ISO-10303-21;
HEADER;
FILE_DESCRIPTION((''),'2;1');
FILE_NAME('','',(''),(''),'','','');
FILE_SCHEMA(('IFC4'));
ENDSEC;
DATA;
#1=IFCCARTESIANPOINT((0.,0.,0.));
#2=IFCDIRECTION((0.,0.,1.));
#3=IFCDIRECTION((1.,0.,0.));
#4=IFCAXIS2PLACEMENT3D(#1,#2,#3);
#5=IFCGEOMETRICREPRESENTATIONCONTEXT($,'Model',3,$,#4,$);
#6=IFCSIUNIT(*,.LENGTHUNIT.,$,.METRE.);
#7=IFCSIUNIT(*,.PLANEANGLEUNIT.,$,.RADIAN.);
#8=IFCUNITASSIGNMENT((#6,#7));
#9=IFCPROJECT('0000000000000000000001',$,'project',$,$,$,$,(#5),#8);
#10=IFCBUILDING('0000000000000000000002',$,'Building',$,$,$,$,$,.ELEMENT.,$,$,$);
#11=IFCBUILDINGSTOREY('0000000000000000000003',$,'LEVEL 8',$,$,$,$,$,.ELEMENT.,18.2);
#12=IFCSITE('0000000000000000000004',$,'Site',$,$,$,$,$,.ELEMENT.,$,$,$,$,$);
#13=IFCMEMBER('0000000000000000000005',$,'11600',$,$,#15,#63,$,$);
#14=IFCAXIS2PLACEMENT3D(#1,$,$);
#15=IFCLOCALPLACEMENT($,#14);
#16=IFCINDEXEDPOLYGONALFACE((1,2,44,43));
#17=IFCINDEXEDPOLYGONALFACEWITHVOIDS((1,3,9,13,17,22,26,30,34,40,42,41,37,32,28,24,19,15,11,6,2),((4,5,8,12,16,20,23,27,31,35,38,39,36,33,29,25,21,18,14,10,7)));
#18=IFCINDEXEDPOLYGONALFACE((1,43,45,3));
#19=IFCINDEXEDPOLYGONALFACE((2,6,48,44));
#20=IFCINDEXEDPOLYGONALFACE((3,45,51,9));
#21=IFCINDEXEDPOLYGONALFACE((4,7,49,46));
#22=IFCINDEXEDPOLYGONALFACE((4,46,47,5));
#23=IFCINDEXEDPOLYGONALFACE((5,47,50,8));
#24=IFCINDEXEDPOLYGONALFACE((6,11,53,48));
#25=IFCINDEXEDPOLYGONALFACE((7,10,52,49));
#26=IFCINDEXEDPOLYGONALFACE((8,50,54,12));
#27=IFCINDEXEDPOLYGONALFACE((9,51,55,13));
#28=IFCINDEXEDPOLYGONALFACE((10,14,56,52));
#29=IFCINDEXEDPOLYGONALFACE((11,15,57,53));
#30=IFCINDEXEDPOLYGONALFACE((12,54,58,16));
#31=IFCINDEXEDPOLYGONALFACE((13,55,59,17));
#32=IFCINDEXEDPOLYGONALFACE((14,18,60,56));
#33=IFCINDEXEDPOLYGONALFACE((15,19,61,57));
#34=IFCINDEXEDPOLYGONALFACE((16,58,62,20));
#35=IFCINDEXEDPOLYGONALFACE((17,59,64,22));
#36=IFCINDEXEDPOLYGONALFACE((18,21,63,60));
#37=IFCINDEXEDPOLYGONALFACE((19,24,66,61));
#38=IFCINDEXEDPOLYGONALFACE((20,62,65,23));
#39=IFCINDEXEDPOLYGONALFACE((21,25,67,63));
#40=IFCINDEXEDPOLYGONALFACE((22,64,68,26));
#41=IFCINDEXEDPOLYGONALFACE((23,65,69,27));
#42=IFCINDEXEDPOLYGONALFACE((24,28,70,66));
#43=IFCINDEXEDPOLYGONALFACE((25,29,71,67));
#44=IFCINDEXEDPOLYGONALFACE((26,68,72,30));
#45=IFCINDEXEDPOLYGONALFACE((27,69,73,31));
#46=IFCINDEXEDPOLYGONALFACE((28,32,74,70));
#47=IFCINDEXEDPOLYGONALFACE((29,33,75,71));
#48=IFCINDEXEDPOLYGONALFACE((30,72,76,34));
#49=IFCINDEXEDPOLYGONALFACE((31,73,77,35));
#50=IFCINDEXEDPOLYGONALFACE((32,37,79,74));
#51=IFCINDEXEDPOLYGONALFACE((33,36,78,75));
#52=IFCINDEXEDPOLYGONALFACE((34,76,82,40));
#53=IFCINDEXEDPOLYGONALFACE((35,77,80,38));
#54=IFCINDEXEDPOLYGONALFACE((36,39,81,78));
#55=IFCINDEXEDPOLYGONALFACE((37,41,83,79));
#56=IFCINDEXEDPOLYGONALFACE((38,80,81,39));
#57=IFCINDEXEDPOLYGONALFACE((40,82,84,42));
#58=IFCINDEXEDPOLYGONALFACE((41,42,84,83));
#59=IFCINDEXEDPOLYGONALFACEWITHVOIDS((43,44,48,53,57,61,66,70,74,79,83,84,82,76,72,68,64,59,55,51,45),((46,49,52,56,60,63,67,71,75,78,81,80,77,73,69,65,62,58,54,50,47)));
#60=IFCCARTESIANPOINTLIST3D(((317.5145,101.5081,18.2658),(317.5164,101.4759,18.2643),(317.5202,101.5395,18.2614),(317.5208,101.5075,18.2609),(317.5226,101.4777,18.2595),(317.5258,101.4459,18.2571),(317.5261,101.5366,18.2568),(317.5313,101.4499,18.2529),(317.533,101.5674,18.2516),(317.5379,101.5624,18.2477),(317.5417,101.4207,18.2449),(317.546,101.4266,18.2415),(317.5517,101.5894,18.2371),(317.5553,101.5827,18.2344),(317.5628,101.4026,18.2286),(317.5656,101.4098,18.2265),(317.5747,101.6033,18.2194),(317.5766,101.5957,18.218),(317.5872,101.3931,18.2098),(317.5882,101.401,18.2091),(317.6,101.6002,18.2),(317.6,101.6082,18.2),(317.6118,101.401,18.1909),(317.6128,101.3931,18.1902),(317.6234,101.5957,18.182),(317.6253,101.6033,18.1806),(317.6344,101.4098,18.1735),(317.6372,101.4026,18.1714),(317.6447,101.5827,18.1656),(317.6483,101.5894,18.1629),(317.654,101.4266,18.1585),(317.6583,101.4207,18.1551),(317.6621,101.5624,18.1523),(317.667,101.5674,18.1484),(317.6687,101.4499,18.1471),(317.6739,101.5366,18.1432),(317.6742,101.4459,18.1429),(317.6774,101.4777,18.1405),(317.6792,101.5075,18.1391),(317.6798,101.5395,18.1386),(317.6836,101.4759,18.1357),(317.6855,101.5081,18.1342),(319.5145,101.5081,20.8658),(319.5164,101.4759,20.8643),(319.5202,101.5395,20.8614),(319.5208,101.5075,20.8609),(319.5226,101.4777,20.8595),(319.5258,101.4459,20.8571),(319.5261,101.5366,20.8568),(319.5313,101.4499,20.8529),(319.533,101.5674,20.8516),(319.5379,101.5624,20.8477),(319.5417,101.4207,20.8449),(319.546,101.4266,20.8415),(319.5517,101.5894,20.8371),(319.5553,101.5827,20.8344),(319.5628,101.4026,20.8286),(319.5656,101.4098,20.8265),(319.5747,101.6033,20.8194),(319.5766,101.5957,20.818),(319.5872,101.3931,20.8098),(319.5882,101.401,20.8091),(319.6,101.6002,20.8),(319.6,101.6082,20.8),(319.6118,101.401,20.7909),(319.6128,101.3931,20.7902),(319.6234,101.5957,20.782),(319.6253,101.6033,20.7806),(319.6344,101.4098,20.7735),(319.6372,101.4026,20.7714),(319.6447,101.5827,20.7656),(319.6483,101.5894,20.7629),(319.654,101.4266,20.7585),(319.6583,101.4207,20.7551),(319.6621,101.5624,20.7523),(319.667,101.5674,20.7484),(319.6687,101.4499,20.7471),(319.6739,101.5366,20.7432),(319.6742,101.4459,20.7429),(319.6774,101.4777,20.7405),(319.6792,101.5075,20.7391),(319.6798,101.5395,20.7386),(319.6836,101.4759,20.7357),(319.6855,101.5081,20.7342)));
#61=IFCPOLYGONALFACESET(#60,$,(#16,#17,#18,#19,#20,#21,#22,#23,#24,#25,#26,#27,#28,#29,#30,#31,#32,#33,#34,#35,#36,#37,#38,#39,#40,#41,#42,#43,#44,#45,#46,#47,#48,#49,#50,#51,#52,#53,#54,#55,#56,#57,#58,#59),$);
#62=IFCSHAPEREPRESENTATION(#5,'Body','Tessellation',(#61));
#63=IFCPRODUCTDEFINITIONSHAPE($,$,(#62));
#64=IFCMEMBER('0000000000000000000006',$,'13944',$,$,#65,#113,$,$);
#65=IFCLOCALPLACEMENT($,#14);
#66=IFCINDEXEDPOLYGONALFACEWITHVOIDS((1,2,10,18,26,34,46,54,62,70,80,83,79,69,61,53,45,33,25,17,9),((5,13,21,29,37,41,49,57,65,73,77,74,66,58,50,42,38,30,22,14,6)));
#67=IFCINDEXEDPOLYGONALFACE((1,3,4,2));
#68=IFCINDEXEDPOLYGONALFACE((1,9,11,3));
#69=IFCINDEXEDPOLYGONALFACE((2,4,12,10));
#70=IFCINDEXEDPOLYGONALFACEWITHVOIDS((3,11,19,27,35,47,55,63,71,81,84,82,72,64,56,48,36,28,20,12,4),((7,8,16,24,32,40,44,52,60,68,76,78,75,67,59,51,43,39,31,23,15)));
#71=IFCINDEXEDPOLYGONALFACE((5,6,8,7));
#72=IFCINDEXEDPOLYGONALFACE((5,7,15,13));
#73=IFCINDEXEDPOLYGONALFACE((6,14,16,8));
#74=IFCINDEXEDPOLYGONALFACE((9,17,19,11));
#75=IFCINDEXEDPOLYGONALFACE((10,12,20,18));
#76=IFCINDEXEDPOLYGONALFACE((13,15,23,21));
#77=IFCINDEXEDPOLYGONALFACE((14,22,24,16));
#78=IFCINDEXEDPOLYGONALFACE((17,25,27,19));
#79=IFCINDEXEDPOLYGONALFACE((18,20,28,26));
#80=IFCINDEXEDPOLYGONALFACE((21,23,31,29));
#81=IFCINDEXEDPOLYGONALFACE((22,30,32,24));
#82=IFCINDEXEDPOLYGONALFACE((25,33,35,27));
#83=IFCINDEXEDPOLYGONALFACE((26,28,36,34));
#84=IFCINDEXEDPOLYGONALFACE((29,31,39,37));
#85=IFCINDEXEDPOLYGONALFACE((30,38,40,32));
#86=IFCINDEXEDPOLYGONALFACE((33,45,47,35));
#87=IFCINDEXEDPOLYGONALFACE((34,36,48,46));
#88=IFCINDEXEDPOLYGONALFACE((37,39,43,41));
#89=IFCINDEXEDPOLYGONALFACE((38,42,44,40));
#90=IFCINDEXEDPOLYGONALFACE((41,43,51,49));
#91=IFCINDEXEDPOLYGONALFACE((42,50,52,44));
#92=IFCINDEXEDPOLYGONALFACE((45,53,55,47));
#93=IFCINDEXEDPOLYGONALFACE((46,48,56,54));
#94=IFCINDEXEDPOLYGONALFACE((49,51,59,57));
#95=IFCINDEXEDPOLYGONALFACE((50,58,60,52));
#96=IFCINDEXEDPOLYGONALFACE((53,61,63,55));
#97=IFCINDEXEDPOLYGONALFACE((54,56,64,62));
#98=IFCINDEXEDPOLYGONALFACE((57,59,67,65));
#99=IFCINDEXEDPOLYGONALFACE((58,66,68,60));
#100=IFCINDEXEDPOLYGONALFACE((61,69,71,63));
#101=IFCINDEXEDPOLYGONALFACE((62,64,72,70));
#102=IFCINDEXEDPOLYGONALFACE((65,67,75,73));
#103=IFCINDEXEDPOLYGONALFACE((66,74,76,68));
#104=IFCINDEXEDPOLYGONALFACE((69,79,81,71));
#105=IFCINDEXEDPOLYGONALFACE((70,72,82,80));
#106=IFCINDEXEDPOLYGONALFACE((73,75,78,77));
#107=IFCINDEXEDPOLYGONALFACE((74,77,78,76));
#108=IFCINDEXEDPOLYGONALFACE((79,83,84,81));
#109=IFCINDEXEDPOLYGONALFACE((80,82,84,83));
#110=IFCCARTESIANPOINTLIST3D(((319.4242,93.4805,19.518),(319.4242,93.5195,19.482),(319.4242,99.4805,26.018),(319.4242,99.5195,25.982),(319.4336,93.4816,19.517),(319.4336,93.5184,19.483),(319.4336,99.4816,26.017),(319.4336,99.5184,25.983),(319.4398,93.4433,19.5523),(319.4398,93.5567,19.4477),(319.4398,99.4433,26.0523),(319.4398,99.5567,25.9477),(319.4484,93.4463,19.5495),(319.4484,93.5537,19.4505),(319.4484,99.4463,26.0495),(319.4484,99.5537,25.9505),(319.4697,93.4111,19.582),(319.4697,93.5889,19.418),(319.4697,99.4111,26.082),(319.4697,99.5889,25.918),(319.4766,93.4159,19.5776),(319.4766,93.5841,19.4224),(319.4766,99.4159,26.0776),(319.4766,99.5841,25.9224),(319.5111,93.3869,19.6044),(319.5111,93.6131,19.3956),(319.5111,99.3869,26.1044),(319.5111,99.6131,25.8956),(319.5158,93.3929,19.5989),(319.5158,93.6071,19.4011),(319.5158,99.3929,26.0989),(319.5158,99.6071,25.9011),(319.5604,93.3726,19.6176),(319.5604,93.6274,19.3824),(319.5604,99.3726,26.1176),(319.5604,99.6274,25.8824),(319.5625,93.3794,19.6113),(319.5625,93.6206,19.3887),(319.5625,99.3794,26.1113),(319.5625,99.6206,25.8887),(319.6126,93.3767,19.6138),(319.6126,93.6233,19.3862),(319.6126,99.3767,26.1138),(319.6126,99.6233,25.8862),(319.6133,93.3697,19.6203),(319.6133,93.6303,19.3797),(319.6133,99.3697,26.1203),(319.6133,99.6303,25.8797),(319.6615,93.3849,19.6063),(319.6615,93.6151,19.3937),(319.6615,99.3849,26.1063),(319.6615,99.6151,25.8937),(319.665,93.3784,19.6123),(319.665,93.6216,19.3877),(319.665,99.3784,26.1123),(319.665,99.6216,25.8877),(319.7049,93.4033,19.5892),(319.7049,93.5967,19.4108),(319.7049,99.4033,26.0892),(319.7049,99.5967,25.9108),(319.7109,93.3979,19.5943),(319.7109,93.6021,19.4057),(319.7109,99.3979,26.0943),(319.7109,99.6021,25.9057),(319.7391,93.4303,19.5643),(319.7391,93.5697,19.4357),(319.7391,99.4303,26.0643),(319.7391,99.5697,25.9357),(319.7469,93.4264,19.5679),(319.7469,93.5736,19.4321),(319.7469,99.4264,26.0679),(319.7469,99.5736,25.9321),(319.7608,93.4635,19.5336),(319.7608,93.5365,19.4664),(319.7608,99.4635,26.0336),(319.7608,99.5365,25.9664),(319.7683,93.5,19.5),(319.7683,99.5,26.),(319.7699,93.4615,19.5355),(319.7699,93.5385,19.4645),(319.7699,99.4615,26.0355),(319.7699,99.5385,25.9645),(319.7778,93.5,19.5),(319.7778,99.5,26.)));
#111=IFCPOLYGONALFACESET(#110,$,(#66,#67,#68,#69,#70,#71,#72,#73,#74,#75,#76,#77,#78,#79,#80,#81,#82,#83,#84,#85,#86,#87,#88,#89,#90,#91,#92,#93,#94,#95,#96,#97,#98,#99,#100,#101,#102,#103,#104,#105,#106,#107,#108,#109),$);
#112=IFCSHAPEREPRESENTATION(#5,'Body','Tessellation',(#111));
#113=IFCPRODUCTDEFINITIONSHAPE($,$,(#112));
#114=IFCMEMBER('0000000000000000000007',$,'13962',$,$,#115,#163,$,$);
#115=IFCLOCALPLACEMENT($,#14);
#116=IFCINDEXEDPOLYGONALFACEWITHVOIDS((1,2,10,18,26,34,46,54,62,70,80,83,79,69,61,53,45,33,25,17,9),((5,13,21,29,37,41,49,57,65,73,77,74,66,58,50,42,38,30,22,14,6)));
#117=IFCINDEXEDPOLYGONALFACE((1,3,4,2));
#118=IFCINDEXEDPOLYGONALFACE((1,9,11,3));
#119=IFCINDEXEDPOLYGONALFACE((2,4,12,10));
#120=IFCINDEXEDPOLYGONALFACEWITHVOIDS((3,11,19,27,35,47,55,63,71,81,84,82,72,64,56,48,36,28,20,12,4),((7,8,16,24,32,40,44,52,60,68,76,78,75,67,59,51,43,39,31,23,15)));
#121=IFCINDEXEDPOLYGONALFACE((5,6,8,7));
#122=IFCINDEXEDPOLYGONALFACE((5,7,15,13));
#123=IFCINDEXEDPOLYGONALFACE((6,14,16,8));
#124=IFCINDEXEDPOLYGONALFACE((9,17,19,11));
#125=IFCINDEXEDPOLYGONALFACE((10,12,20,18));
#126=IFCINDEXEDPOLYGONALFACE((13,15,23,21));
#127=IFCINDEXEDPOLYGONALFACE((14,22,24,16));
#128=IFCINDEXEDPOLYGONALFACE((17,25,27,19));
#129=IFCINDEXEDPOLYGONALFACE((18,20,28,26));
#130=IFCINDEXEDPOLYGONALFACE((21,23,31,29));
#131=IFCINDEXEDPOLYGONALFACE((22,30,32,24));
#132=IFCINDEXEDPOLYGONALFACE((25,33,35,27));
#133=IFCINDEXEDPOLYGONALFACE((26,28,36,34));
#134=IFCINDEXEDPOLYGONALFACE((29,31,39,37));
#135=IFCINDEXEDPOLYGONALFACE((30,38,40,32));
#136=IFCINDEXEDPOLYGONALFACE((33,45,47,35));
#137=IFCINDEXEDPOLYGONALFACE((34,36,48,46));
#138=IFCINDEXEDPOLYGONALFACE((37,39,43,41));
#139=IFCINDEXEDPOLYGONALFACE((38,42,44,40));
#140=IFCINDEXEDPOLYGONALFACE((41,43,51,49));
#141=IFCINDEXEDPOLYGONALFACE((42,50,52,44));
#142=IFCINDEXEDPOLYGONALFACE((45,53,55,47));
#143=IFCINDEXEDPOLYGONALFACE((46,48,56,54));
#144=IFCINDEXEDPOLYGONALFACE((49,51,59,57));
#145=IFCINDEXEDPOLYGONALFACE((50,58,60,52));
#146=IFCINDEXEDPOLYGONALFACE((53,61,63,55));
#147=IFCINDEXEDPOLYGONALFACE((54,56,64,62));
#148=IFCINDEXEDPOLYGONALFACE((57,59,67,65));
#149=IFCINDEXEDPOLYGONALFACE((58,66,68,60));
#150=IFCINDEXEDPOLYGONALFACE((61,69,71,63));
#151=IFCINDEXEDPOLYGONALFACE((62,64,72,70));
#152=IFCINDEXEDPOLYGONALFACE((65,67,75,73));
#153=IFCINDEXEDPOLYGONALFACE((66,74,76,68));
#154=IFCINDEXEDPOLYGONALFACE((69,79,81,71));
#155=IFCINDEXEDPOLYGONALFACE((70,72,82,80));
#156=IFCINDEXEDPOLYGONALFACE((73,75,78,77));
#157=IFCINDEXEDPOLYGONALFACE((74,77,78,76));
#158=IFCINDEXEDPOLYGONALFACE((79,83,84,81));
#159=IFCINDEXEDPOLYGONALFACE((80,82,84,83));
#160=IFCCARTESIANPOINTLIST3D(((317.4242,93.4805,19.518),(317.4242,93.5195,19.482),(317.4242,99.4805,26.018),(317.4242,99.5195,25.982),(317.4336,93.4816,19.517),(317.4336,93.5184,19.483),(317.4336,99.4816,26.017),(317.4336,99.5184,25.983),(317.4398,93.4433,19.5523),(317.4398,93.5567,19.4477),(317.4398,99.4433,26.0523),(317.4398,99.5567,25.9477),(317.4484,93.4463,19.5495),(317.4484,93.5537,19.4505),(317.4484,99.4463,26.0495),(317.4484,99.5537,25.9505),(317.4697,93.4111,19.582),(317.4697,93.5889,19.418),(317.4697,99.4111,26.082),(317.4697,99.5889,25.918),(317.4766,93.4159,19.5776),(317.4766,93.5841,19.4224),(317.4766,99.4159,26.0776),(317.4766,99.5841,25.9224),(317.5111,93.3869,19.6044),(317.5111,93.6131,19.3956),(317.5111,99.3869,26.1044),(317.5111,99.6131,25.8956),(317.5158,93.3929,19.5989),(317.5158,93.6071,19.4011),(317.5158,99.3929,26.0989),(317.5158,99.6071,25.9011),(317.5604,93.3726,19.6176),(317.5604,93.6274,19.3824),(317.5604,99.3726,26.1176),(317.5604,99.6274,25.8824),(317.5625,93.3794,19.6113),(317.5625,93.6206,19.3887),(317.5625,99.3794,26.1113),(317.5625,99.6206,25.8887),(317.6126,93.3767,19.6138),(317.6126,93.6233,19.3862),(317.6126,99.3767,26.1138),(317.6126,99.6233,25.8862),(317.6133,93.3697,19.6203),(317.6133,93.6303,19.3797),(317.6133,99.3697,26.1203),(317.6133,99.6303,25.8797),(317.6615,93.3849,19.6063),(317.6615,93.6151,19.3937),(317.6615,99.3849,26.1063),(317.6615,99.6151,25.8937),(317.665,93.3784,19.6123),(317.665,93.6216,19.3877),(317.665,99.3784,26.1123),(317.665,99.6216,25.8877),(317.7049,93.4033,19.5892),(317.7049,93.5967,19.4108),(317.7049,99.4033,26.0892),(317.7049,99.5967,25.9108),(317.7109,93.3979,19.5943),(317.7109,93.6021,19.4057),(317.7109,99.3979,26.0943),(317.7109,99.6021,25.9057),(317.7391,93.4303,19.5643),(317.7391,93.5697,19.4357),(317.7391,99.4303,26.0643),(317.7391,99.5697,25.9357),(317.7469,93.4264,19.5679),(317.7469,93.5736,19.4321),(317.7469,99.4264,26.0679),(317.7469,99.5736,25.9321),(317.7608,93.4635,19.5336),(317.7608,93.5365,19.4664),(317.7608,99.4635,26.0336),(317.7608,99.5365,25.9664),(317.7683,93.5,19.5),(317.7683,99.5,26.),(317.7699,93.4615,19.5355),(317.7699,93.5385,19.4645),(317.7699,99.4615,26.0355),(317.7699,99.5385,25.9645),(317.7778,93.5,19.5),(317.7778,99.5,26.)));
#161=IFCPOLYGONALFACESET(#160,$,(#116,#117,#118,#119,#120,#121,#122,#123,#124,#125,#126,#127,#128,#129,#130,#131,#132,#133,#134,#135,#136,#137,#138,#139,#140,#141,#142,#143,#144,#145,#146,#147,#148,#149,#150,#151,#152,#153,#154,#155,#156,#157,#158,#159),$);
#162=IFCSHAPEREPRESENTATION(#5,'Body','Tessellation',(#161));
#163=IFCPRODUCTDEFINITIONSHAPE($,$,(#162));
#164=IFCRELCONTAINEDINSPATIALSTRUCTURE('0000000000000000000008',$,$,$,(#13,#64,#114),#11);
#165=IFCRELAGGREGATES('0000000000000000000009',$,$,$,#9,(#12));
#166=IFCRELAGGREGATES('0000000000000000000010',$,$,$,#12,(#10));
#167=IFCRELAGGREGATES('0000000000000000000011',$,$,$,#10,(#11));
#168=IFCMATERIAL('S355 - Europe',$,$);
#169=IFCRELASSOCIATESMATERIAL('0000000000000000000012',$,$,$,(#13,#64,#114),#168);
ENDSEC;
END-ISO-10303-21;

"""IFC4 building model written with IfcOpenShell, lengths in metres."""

from ifc_helpers import new_model, si_unit, frame, origin_with_axes, origin_2d_with_axis, place, context, project, spatial, hollow_circle, extrude, material, material_profile, profile_set, profile_usage, element, save


model = new_model("IFC4")

# Units and contexts
model_context = context("Model", 3, world=origin_with_axes())
ifc_project = project(units=[si_unit("LENGTHUNIT", "METRE"), si_unit("PLANEANGLEUNIT", "RADIAN")], contexts=[model_context])

# Site, building, storey
site = spatial("IfcSite", under=ifc_project, Name="Site", CompositionType="ELEMENT")
building = spatial("IfcBuilding", under=site, Name="Building", CompositionType="ELEMENT")
storey = spatial("IfcBuildingStorey", under=building, Name="LEVEL 8", CompositionType="ELEMENT", Elevation=18.2)

# Shared definitions
ifc_material = material(Name="S355 - Europe")

# Members
ifc_material_profile_1 = material_profile(ifc_material, hollow_circle(Radius=0.1081, WallThickness=0.008, at=origin_2d_with_axis()))
ifc_profile_set_1 = profile_set([ifc_material_profile_1])
ifc_profile_usage_1 = profile_usage(ifc_profile_set_1, cardinal=10)
member_1_placement = place(None, frame((317.6, 101.5, 18.2), z_axis=(0.609711, 0.0, 0.792624), x_axis=(0.0, 1.0, 0.0)))
element("IfcMember", 1, at=member_1_placement, inside=storey, material=ifc_profile_usage_1, Name="11600", context=model_context, shape_type="SweptSolid", body=[
    extrude(hollow_circle(Radius=0.1081, WallThickness=0.008, at=origin_2d_with_axis()), origin_with_axes(), (0.0, 0.0, 1.0), 3.2802),
])
ifc_material_profile_2 = material_profile(ifc_material, hollow_circle(Radius=0.1778, WallThickness=0.0095, at=origin_2d_with_axis()))
ifc_profile_set_2 = profile_set([ifc_material_profile_2])
ifc_profile_usage_2 = profile_usage(ifc_profile_set_2, cardinal=10)
member_2_placement = place(None, frame((319.6, 99.5, 26.0), z_axis=(0.0, -0.67828, -0.734803), x_axis=(1.0, 0.0, 0.0)))
element("IfcMember", 2, at=member_2_placement, inside=storey, material=ifc_profile_usage_2, Name="13944", context=model_context, shape_type="SweptSolid", body=[
    extrude(hollow_circle(Radius=0.1778, WallThickness=0.0095, at=origin_2d_with_axis()), origin_with_axes(), (0.0, 0.0, 1.0), 8.8459),
])
ifc_material_profile_3 = material_profile(ifc_material, hollow_circle(Radius=0.1778, WallThickness=0.0095, at=origin_2d_with_axis()))
ifc_profile_set_3 = profile_set([ifc_material_profile_3])
ifc_profile_usage_3 = profile_usage(ifc_profile_set_3, cardinal=10)
member_3_placement = place(None, frame((317.6, 99.5, 26.0), z_axis=(0.0, -0.67828, -0.734803), x_axis=(1.0, 0.0, 0.0)))
element("IfcMember", 3, at=member_3_placement, inside=storey, material=ifc_profile_usage_3, Name="13962", context=model_context, shape_type="SweptSolid", body=[
    extrude(hollow_circle(Radius=0.1778, WallThickness=0.0095, at=origin_2d_with_axis()), origin_with_axes(), (0.0, 0.0, 1.0), 8.8459),
])

save(model, "model.ifc")
